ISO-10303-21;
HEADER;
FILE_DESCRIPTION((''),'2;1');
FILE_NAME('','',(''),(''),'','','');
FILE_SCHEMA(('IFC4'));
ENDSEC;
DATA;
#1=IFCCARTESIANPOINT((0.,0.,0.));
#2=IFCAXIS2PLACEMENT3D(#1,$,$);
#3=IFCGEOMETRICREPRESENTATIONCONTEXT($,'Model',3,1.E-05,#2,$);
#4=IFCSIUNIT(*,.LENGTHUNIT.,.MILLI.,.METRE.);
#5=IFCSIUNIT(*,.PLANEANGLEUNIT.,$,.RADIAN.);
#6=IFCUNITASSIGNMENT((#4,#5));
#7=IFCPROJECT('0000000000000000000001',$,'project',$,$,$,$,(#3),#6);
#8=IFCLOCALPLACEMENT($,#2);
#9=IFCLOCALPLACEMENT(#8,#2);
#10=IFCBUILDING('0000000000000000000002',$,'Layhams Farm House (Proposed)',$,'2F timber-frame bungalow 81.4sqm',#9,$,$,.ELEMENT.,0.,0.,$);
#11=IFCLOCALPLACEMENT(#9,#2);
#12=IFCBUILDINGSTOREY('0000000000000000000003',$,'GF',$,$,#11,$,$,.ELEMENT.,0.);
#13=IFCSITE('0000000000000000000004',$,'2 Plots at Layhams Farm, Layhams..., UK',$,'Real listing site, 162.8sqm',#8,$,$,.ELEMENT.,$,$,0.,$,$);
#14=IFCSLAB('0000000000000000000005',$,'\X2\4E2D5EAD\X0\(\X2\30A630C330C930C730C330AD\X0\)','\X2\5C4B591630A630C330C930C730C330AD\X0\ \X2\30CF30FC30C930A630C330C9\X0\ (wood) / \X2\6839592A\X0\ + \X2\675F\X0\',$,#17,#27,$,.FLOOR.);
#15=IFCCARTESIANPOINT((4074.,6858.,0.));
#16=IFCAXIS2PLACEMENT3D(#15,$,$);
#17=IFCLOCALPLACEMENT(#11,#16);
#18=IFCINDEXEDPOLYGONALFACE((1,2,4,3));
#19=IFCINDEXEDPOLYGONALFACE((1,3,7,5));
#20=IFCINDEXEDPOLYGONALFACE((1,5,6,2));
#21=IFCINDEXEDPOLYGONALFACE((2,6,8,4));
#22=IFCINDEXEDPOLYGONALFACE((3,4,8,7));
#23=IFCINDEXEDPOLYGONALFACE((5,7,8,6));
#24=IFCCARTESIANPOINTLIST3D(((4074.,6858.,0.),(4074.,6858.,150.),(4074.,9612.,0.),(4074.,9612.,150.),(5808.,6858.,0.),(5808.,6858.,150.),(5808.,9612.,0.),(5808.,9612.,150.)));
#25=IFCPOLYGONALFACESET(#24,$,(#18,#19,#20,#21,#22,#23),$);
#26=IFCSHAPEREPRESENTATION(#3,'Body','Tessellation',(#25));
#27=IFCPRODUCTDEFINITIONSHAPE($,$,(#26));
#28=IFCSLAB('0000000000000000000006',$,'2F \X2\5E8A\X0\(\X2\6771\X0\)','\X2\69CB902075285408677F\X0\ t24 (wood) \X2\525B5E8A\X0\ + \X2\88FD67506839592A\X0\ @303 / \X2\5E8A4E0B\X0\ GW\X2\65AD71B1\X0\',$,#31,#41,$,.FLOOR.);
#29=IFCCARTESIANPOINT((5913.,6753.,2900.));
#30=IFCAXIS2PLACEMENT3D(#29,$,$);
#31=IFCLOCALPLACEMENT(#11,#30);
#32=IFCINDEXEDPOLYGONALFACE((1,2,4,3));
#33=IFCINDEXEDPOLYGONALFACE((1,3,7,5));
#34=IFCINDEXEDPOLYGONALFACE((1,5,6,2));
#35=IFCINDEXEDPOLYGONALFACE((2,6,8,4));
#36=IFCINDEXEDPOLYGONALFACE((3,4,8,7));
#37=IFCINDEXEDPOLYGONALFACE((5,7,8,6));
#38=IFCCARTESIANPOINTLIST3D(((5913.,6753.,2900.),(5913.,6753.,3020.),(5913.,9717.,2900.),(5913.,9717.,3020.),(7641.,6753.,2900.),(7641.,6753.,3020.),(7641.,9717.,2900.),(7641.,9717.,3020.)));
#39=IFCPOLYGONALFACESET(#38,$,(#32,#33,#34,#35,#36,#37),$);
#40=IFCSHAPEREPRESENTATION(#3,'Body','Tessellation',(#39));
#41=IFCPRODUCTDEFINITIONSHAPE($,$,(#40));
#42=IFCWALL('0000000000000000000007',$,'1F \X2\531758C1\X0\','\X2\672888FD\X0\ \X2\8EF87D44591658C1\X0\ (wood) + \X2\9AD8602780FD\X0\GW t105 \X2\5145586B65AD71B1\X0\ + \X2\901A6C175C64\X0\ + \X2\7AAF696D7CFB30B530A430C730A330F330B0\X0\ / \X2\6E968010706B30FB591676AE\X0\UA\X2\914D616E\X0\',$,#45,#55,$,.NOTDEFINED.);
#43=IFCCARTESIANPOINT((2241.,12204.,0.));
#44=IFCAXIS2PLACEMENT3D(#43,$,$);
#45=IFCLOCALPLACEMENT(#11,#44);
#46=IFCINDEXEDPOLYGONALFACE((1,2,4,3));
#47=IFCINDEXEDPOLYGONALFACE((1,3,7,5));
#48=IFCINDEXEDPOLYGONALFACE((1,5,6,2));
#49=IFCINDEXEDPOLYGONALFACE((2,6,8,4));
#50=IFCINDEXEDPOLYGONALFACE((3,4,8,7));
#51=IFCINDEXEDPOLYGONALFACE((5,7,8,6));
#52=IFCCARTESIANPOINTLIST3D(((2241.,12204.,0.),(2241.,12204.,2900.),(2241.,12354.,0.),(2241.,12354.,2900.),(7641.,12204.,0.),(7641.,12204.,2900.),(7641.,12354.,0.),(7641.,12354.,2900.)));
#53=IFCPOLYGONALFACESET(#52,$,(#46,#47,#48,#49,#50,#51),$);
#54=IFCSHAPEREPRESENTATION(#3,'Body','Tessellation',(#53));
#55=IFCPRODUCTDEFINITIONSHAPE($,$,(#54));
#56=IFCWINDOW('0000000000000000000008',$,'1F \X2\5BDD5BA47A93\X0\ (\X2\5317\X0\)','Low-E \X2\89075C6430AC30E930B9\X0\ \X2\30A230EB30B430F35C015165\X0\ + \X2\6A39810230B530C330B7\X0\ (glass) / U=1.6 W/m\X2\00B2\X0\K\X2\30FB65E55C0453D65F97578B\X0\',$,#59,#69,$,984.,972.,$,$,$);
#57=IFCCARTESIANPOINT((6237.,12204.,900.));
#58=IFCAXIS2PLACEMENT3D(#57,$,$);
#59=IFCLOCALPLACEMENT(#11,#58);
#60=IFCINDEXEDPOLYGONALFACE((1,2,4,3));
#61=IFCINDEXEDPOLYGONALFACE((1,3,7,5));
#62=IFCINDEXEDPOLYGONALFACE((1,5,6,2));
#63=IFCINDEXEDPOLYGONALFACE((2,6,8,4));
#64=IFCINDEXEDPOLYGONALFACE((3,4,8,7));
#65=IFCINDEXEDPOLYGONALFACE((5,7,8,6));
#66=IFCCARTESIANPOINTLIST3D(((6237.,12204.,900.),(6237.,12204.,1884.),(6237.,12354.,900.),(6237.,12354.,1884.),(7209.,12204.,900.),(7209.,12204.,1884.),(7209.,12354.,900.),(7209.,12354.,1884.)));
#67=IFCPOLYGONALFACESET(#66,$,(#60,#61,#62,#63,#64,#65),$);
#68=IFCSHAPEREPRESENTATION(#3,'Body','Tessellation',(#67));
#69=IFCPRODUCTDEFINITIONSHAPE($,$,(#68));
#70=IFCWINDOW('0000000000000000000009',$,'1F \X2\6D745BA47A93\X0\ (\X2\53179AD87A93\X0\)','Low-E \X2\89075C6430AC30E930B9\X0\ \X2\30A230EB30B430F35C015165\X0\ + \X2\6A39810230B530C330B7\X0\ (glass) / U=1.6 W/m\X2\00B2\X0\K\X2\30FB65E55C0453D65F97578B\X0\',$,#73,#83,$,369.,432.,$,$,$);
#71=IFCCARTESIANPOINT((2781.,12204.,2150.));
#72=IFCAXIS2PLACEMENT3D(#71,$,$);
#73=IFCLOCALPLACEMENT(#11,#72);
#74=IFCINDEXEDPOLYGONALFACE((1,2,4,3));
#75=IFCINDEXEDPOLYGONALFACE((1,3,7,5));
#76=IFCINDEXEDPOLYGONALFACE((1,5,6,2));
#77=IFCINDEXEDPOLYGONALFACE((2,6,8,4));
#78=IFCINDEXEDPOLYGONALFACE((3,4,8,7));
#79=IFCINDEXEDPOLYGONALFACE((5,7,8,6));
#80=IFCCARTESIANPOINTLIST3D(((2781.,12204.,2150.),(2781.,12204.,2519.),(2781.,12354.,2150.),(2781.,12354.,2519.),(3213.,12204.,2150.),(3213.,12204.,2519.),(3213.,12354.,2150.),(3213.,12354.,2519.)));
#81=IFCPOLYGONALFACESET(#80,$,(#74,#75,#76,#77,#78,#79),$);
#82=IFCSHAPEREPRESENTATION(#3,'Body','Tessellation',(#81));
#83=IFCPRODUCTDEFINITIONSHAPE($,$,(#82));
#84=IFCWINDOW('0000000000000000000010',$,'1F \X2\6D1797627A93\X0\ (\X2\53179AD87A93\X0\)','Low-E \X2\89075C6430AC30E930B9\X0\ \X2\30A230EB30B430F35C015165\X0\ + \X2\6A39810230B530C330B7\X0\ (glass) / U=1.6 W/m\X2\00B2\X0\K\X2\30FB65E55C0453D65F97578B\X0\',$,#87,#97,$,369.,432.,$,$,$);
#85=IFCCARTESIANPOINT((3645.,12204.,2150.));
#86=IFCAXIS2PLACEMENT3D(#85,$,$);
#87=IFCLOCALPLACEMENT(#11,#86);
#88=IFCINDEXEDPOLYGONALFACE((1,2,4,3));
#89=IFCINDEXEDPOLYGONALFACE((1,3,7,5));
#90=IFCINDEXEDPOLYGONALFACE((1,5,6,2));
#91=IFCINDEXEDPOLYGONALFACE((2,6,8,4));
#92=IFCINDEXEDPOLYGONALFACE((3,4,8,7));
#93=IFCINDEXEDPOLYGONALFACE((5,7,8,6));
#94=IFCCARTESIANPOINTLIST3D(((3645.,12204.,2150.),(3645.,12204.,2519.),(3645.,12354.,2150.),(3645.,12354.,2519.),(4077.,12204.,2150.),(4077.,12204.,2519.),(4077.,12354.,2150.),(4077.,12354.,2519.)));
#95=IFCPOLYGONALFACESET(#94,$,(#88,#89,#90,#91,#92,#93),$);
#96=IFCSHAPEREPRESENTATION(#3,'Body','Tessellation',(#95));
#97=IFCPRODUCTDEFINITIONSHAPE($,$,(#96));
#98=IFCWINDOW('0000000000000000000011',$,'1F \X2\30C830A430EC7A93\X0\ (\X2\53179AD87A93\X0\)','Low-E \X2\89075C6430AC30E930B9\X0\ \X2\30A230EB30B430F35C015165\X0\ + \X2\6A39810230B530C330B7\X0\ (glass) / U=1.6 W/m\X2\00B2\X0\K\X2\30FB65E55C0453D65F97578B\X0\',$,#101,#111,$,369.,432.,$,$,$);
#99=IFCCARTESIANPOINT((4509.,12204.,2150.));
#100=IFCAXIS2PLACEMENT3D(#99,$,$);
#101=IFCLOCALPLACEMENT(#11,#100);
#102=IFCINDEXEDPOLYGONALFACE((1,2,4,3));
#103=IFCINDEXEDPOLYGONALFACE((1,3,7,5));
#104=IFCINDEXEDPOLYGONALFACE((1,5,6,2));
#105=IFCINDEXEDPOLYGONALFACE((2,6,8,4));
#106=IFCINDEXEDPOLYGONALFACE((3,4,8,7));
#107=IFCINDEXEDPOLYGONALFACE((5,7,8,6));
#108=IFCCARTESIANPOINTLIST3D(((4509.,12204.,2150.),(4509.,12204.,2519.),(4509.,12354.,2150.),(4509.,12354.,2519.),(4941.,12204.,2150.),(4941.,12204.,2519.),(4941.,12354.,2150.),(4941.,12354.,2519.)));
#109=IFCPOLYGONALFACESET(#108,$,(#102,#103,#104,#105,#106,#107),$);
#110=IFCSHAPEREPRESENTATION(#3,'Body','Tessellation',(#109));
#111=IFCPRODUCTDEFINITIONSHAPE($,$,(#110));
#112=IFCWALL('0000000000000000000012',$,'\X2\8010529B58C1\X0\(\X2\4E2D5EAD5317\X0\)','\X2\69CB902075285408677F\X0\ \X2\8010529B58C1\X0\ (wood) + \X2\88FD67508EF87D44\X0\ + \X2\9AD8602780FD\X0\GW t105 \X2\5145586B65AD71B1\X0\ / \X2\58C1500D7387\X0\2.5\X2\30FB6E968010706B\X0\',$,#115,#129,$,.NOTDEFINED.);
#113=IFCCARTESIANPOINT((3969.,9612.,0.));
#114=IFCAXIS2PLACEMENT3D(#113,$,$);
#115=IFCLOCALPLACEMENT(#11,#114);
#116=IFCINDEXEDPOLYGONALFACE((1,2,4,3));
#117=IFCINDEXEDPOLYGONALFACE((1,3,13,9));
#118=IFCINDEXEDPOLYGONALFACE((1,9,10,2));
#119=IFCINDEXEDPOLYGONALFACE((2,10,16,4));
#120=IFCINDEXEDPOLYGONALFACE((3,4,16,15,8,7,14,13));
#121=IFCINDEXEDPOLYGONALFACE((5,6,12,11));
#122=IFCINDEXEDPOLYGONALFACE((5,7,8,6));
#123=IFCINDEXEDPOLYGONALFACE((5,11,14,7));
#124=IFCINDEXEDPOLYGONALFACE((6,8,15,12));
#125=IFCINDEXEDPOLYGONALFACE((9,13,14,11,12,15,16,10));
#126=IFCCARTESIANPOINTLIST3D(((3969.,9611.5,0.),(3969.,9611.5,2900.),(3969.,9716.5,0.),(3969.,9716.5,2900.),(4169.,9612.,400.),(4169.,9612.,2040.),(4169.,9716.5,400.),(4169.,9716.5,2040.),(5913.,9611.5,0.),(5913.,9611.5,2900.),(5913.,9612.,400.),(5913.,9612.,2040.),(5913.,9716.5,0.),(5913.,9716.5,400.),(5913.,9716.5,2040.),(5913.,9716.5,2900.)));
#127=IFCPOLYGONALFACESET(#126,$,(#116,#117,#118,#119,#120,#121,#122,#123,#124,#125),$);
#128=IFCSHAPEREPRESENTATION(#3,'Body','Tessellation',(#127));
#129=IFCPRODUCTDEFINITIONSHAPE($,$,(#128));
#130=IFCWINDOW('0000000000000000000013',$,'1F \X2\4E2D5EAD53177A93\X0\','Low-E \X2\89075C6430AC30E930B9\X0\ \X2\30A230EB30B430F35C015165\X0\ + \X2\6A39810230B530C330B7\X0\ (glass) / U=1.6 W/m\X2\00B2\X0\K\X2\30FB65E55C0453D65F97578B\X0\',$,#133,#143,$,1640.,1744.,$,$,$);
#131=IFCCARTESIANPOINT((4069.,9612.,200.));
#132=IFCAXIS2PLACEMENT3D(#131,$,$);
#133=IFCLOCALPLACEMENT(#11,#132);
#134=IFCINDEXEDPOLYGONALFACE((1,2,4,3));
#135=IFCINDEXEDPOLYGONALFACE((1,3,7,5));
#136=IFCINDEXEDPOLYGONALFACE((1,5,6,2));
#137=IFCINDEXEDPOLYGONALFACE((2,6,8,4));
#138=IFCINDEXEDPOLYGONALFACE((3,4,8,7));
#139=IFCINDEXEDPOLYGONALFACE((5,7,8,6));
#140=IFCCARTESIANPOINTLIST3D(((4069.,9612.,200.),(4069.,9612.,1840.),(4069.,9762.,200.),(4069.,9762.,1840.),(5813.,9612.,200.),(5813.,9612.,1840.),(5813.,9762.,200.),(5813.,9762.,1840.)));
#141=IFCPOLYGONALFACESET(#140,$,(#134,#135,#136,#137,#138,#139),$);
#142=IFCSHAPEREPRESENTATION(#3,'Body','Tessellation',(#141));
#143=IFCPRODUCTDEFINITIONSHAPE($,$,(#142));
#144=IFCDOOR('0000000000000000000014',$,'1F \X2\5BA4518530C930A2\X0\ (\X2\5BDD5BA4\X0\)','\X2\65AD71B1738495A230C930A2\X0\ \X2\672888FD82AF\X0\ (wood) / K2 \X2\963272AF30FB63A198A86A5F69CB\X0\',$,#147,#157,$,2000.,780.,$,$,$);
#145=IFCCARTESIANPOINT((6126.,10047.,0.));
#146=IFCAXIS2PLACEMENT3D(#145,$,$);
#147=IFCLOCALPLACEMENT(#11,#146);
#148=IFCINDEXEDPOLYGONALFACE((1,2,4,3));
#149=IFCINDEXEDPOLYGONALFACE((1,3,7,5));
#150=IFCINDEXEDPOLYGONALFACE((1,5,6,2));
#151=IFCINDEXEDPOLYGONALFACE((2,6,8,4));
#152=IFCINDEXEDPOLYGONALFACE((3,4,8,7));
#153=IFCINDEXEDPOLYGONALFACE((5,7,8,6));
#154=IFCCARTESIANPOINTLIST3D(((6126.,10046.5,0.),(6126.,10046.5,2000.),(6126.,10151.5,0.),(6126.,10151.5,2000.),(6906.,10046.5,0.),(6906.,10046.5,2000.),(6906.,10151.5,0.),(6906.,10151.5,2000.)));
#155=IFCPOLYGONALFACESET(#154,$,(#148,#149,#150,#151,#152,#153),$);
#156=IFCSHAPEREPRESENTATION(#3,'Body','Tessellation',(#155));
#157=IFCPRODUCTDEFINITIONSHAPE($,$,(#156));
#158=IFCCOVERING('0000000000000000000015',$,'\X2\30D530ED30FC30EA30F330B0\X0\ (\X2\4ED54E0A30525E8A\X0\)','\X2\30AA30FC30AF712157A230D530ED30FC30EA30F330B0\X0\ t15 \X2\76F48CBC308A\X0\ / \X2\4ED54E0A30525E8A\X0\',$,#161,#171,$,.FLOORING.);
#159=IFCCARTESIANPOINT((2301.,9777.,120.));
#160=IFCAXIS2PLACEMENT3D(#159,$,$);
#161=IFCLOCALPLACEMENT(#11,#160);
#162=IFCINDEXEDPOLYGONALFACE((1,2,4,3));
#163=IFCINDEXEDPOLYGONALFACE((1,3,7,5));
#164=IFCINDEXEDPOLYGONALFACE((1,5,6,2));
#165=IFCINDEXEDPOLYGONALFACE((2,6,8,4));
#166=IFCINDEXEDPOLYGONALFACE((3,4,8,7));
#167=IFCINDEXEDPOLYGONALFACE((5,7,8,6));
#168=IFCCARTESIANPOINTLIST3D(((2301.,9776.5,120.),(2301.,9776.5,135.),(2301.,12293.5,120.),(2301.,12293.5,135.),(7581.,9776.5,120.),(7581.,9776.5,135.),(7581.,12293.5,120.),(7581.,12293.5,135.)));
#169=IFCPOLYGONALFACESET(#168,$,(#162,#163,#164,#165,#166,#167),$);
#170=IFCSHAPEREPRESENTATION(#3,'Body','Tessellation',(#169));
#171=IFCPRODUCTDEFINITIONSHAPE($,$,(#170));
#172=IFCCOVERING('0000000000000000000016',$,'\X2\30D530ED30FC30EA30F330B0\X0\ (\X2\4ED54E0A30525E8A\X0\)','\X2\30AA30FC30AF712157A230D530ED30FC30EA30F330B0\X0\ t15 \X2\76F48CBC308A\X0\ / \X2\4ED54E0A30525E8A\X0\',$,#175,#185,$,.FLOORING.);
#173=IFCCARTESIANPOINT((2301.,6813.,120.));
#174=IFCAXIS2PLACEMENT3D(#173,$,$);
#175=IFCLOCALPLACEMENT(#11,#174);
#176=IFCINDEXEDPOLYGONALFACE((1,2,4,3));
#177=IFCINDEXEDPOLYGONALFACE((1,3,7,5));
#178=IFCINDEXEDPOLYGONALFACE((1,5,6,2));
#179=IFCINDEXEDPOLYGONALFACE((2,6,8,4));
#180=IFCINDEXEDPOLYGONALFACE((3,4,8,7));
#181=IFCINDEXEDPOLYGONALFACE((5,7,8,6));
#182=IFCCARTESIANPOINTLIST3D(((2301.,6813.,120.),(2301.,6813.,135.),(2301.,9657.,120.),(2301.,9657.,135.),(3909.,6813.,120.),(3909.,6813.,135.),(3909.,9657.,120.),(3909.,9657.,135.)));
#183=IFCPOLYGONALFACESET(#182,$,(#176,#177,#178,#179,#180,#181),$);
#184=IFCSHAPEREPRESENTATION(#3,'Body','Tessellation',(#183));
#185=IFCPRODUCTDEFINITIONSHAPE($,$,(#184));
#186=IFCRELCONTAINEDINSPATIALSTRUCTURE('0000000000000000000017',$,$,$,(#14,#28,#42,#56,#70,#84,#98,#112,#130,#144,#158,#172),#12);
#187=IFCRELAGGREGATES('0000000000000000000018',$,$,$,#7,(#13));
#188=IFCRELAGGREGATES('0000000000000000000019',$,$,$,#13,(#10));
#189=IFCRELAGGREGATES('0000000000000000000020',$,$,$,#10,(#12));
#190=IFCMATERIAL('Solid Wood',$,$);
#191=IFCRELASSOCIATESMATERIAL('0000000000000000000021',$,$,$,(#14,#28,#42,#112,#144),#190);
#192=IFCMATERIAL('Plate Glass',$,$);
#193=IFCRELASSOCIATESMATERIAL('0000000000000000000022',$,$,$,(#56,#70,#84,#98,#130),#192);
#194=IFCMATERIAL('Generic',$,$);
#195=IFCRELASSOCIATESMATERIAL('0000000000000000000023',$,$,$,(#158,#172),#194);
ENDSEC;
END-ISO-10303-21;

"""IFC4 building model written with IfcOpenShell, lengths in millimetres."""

from ifc_helpers import new_model, si_unit, frame, frame_2d, origin, place, context, project, spatial, rectangle, extrude, material, element, fill, save


model = new_model("IFC4")

# Units and contexts
model_context = context("Model", 3, precision=1e-05, world=origin())
ifc_project = project(units=[si_unit("LENGTHUNIT", "METRE", prefix="MILLI"), si_unit("PLANEANGLEUNIT", "RADIAN")], contexts=[model_context])

# Site, building, storey
site_placement = place(None, origin())
site = spatial("IfcSite", under=ifc_project, at=site_placement, Name="2 Plots at Layhams Farm, Layhams..., UK", ObjectType="Real listing site, 162.8sqm", CompositionType="ELEMENT", RefElevation=0.0)
building_placement = place(site_placement, origin())
building = spatial("IfcBuilding", under=site, at=building_placement, Name="Layhams Farm House (Proposed)", ObjectType="2F timber-frame bungalow 81.4sqm", CompositionType="ELEMENT", ElevationOfRefHeight=0.0, ElevationOfTerrain=0.0)
storey_placement = place(building_placement, origin())
storey = spatial("IfcBuildingStorey", under=building, at=storey_placement, Name="GF", CompositionType="ELEMENT", Elevation=0.0)

# Slabs
ifc_material_1 = material(Name="Solid Wood")
slab_1_placement = place(storey_placement, frame((4074.0, 6858.0, 0.0)))
element("IfcSlab", 1, at=slab_1_placement, inside=storey, material=ifc_material_1, Name="中庭(ウッドデッキ)", Description="屋外ウッドデッキ ハードウッド (wood) / 根太 + 束", PredefinedType="FLOOR", context=model_context, shape_type="SweptSolid", body=[
    extrude(rectangle(XDim=1734.0, YDim=2754.0, at=frame_2d((867.0, 1377.0))), frame((4074.0, 6858.0, 0.0)), (0.0, 0.0, 1.0), 150.0),
])
slab_2_placement = place(storey_placement, frame((5913.0, 6753.0, 2900.0)))
element("IfcSlab", 2, at=slab_2_placement, inside=storey, material=ifc_material_1, Name="2F 床(東)", Description="構造用合板 t24 (wood) 剛床 + 製材根太 @303 / 床下 GW断熱", PredefinedType="FLOOR", context=model_context, shape_type="SweptSolid", body=[
    extrude(rectangle(XDim=1728.0, YDim=2964.0, at=frame_2d((864.0, 1482.0))), frame((5913.0, 6753.0, 2900.0)), (0.0, 0.0, 1.0), 120.0),
])

# Wall, openings, windows
wall_1_placement = place(storey_placement, frame((2241.0, 12204.0, 0.0)))
wall_1 = element("IfcWall", 3, at=wall_1_placement, inside=storey, material=ifc_material_1, Name="1F 北壁", Description="木製 軸組外壁 (wood) + 高性能GW t105 充填断熱 + 通気層 + 窯業系サイディング / 準耐火・外皮UA配慮", PredefinedType="NOTDEFINED", context=model_context, shape_type="SweptSolid", body=[
    extrude(rectangle(XDim=5400.0, YDim=150.0, at=frame_2d((2700.0, 75.0))), frame((2241.0, 12204.0, 0.0)), (0.0, 0.0, 1.0), 2900.0),
])
opening_1_placement = place(storey_placement, frame((6237.0, 12204.0, 900.0)))
opening_1 = element("IfcOpeningElement", 4, at=opening_1_placement, cuts=wall_1, PredefinedType="NOTDEFINED", context=model_context, shape_type="SweptSolid", body=[
    extrude(rectangle(XDim=972.0, YDim=150.0, at=frame_2d((486.0, 75.0))), frame((6237.0, 12204.0, 900.0)), (0.0, 0.0, 1.0), 984.0),
])
opening_2_placement = place(storey_placement, frame((2781.0, 12204.0, 2150.0)))
opening_2 = element("IfcOpeningElement", 5, at=opening_2_placement, cuts=wall_1, PredefinedType="NOTDEFINED", context=model_context, shape_type="SweptSolid", body=[
    extrude(rectangle(XDim=432.0, YDim=150.0, at=frame_2d((216.0, 75.0))), frame((2781.0, 12204.0, 2150.0)), (0.0, 0.0, 1.0), 369.0),
])
opening_3_placement = place(storey_placement, frame((3645.0, 12204.0, 2150.0)))
opening_3 = element("IfcOpeningElement", 6, at=opening_3_placement, cuts=wall_1, PredefinedType="NOTDEFINED", context=model_context, shape_type="SweptSolid", body=[
    extrude(rectangle(XDim=432.0, YDim=150.0, at=frame_2d((216.0, 75.0))), frame((3645.0, 12204.0, 2150.0)), (0.0, 0.0, 1.0), 369.0),
])
opening_4_placement = place(storey_placement, frame((4509.0, 12204.0, 2150.0)))
opening_4 = element("IfcOpeningElement", 7, at=opening_4_placement, cuts=wall_1, PredefinedType="NOTDEFINED", context=model_context, shape_type="SweptSolid", body=[
    extrude(rectangle(XDim=432.0, YDim=150.0, at=frame_2d((216.0, 75.0))), frame((4509.0, 12204.0, 2150.0)), (0.0, 0.0, 1.0), 369.0),
])
ifc_material_2 = material(Name="Plate Glass")
window_1_placement = place(storey_placement, frame((6237.0, 12204.0, 900.0)))
window_1 = element("IfcWindow", 8, at=window_1_placement, inside=storey, material=ifc_material_2, Name="1F 寝室窓 (北)", Description="Low-E 複層ガラス アルゴン封入 + 樹脂サッシ (glass) / U=1.6 W/m²K・日射取得型", OverallHeight=984.0, OverallWidth=972.0, context=model_context, shape_type="SweptSolid", body=[
    extrude(rectangle(XDim=972.0, YDim=150.0, at=frame_2d((486.0, 75.0))), frame((6237.0, 12204.0, 900.0)), (0.0, 0.0, 1.0), 984.0),
])
fill(opening_1, window_1)
window_2_placement = place(storey_placement, frame((2781.0, 12204.0, 2150.0)))
window_2 = element("IfcWindow", 9, at=window_2_placement, inside=storey, material=ifc_material_2, Name="1F 浴室窓 (北高窓)", Description="Low-E 複層ガラス アルゴン封入 + 樹脂サッシ (glass) / U=1.6 W/m²K・日射取得型", OverallHeight=369.0, OverallWidth=432.0, context=model_context, shape_type="SweptSolid", body=[
    extrude(rectangle(XDim=432.0, YDim=150.0, at=frame_2d((216.0, 75.0))), frame((2781.0, 12204.0, 2150.0)), (0.0, 0.0, 1.0), 369.0),
])
fill(opening_2, window_2)
window_3_placement = place(storey_placement, frame((3645.0, 12204.0, 2150.0)))
window_3 = element("IfcWindow", 10, at=window_3_placement, inside=storey, material=ifc_material_2, Name="1F 洗面窓 (北高窓)", Description="Low-E 複層ガラス アルゴン封入 + 樹脂サッシ (glass) / U=1.6 W/m²K・日射取得型", OverallHeight=369.0, OverallWidth=432.0, context=model_context, shape_type="SweptSolid", body=[
    extrude(rectangle(XDim=432.0, YDim=150.0, at=frame_2d((216.0, 75.0))), frame((3645.0, 12204.0, 2150.0)), (0.0, 0.0, 1.0), 369.0),
])
fill(opening_3, window_3)
window_4_placement = place(storey_placement, frame((4509.0, 12204.0, 2150.0)))
window_4 = element("IfcWindow", 11, at=window_4_placement, inside=storey, material=ifc_material_2, Name="1F トイレ窓 (北高窓)", Description="Low-E 複層ガラス アルゴン封入 + 樹脂サッシ (glass) / U=1.6 W/m²K・日射取得型", OverallHeight=369.0, OverallWidth=432.0, context=model_context, shape_type="SweptSolid", body=[
    extrude(rectangle(XDim=432.0, YDim=150.0, at=frame_2d((216.0, 75.0))), frame((4509.0, 12204.0, 2150.0)), (0.0, 0.0, 1.0), 369.0),
])
fill(opening_4, window_4)

# Wall, opening, window
wall_2_placement = place(storey_placement, frame((3969.0, 9612.0, 0.0)))
wall_2 = element("IfcWall", 12, at=wall_2_placement, inside=storey, material=ifc_material_1, Name="耐力壁(中庭北)", Description="構造用合板 耐力壁 (wood) + 製材軸組 + 高性能GW t105 充填断熱 / 壁倍率2.5・準耐火", PredefinedType="NOTDEFINED", context=model_context, shape_type="SweptSolid", body=[
    extrude(rectangle(XDim=1944.0, YDim=105.0, at=frame_2d((972.0, 52.0))), frame((3969.0, 9612.0, 0.0)), (0.0, 0.0, 1.0), 2900.0),
])
opening_5_placement = place(storey_placement, frame((4069.0, 9612.0, 200.0)))
opening_5 = element("IfcOpeningElement", 13, at=opening_5_placement, cuts=wall_2, PredefinedType="NOTDEFINED", context=model_context, shape_type="SweptSolid", body=[
    extrude(rectangle(XDim=1744.0, YDim=150.0, at=frame_2d((872.0, 75.0))), frame((4069.0, 9612.0, 200.0)), (0.0, 0.0, 1.0), 1640.0),
])
window_5_placement = place(storey_placement, frame((4069.0, 9612.0, 200.0)))
window_5 = element("IfcWindow", 14, at=window_5_placement, inside=storey, material=ifc_material_2, Name="1F 中庭北窓", Description="Low-E 複層ガラス アルゴン封入 + 樹脂サッシ (glass) / U=1.6 W/m²K・日射取得型", OverallHeight=1640.0, OverallWidth=1744.0, context=model_context, shape_type="SweptSolid", body=[
    extrude(rectangle(XDim=1744.0, YDim=150.0, at=frame_2d((872.0, 75.0))), frame((4069.0, 9612.0, 200.0)), (0.0, 0.0, 1.0), 1640.0),
])
fill(opening_5, window_5)

# Door
door_1_placement = place(storey_placement, frame((6126.0, 10047.0, 0.0)))
element("IfcDoor", 15, at=door_1_placement, inside=storey, material=ifc_material_1, Name="1F 室内ドア (寝室)", Description="断熱玄関ドア 木製芯 (wood) / K2 防犯・採風機構", OverallHeight=2000.0, OverallWidth=780.0, context=model_context, shape_type="SweptSolid", body=[
    extrude(rectangle(XDim=780.0, YDim=105.0, at=frame_2d((390.0, 52.0))), frame((6126.0, 10047.0, 0.0)), (0.0, 0.0, 1.0), 2000.0),
])

# Coverings
ifc_material_3 = material(Name="Generic")
covering_1_placement = place(storey_placement, frame((2301.0, 9777.0, 120.0)))
element("IfcCovering", 16, at=covering_1_placement, inside=storey, material=ifc_material_3, Name="フローリング (仕上げ床)", Description="オーク無垢フローリング t15 直貼り / 仕上げ床", PredefinedType="FLOORING", context=model_context, shape_type="SweptSolid", body=[
    extrude(rectangle(XDim=5280.0, YDim=2517.0, at=frame_2d((2640.0, 1258.0))), frame((2301.0, 9777.0, 120.0)), (0.0, 0.0, 1.0), 15.0),
])
covering_2_placement = place(storey_placement, frame((2301.0, 6813.0, 120.0)))
element("IfcCovering", 17, at=covering_2_placement, inside=storey, material=ifc_material_3, Name="フローリング (仕上げ床)", Description="オーク無垢フローリング t15 直貼り / 仕上げ床", PredefinedType="FLOORING", context=model_context, shape_type="SweptSolid", body=[
    extrude(rectangle(XDim=1608.0, YDim=2844.0, at=frame_2d((804.0, 1422.0))), frame((2301.0, 6813.0, 120.0)), (0.0, 0.0, 1.0), 15.0),
])

save(model, "model.ifc")
